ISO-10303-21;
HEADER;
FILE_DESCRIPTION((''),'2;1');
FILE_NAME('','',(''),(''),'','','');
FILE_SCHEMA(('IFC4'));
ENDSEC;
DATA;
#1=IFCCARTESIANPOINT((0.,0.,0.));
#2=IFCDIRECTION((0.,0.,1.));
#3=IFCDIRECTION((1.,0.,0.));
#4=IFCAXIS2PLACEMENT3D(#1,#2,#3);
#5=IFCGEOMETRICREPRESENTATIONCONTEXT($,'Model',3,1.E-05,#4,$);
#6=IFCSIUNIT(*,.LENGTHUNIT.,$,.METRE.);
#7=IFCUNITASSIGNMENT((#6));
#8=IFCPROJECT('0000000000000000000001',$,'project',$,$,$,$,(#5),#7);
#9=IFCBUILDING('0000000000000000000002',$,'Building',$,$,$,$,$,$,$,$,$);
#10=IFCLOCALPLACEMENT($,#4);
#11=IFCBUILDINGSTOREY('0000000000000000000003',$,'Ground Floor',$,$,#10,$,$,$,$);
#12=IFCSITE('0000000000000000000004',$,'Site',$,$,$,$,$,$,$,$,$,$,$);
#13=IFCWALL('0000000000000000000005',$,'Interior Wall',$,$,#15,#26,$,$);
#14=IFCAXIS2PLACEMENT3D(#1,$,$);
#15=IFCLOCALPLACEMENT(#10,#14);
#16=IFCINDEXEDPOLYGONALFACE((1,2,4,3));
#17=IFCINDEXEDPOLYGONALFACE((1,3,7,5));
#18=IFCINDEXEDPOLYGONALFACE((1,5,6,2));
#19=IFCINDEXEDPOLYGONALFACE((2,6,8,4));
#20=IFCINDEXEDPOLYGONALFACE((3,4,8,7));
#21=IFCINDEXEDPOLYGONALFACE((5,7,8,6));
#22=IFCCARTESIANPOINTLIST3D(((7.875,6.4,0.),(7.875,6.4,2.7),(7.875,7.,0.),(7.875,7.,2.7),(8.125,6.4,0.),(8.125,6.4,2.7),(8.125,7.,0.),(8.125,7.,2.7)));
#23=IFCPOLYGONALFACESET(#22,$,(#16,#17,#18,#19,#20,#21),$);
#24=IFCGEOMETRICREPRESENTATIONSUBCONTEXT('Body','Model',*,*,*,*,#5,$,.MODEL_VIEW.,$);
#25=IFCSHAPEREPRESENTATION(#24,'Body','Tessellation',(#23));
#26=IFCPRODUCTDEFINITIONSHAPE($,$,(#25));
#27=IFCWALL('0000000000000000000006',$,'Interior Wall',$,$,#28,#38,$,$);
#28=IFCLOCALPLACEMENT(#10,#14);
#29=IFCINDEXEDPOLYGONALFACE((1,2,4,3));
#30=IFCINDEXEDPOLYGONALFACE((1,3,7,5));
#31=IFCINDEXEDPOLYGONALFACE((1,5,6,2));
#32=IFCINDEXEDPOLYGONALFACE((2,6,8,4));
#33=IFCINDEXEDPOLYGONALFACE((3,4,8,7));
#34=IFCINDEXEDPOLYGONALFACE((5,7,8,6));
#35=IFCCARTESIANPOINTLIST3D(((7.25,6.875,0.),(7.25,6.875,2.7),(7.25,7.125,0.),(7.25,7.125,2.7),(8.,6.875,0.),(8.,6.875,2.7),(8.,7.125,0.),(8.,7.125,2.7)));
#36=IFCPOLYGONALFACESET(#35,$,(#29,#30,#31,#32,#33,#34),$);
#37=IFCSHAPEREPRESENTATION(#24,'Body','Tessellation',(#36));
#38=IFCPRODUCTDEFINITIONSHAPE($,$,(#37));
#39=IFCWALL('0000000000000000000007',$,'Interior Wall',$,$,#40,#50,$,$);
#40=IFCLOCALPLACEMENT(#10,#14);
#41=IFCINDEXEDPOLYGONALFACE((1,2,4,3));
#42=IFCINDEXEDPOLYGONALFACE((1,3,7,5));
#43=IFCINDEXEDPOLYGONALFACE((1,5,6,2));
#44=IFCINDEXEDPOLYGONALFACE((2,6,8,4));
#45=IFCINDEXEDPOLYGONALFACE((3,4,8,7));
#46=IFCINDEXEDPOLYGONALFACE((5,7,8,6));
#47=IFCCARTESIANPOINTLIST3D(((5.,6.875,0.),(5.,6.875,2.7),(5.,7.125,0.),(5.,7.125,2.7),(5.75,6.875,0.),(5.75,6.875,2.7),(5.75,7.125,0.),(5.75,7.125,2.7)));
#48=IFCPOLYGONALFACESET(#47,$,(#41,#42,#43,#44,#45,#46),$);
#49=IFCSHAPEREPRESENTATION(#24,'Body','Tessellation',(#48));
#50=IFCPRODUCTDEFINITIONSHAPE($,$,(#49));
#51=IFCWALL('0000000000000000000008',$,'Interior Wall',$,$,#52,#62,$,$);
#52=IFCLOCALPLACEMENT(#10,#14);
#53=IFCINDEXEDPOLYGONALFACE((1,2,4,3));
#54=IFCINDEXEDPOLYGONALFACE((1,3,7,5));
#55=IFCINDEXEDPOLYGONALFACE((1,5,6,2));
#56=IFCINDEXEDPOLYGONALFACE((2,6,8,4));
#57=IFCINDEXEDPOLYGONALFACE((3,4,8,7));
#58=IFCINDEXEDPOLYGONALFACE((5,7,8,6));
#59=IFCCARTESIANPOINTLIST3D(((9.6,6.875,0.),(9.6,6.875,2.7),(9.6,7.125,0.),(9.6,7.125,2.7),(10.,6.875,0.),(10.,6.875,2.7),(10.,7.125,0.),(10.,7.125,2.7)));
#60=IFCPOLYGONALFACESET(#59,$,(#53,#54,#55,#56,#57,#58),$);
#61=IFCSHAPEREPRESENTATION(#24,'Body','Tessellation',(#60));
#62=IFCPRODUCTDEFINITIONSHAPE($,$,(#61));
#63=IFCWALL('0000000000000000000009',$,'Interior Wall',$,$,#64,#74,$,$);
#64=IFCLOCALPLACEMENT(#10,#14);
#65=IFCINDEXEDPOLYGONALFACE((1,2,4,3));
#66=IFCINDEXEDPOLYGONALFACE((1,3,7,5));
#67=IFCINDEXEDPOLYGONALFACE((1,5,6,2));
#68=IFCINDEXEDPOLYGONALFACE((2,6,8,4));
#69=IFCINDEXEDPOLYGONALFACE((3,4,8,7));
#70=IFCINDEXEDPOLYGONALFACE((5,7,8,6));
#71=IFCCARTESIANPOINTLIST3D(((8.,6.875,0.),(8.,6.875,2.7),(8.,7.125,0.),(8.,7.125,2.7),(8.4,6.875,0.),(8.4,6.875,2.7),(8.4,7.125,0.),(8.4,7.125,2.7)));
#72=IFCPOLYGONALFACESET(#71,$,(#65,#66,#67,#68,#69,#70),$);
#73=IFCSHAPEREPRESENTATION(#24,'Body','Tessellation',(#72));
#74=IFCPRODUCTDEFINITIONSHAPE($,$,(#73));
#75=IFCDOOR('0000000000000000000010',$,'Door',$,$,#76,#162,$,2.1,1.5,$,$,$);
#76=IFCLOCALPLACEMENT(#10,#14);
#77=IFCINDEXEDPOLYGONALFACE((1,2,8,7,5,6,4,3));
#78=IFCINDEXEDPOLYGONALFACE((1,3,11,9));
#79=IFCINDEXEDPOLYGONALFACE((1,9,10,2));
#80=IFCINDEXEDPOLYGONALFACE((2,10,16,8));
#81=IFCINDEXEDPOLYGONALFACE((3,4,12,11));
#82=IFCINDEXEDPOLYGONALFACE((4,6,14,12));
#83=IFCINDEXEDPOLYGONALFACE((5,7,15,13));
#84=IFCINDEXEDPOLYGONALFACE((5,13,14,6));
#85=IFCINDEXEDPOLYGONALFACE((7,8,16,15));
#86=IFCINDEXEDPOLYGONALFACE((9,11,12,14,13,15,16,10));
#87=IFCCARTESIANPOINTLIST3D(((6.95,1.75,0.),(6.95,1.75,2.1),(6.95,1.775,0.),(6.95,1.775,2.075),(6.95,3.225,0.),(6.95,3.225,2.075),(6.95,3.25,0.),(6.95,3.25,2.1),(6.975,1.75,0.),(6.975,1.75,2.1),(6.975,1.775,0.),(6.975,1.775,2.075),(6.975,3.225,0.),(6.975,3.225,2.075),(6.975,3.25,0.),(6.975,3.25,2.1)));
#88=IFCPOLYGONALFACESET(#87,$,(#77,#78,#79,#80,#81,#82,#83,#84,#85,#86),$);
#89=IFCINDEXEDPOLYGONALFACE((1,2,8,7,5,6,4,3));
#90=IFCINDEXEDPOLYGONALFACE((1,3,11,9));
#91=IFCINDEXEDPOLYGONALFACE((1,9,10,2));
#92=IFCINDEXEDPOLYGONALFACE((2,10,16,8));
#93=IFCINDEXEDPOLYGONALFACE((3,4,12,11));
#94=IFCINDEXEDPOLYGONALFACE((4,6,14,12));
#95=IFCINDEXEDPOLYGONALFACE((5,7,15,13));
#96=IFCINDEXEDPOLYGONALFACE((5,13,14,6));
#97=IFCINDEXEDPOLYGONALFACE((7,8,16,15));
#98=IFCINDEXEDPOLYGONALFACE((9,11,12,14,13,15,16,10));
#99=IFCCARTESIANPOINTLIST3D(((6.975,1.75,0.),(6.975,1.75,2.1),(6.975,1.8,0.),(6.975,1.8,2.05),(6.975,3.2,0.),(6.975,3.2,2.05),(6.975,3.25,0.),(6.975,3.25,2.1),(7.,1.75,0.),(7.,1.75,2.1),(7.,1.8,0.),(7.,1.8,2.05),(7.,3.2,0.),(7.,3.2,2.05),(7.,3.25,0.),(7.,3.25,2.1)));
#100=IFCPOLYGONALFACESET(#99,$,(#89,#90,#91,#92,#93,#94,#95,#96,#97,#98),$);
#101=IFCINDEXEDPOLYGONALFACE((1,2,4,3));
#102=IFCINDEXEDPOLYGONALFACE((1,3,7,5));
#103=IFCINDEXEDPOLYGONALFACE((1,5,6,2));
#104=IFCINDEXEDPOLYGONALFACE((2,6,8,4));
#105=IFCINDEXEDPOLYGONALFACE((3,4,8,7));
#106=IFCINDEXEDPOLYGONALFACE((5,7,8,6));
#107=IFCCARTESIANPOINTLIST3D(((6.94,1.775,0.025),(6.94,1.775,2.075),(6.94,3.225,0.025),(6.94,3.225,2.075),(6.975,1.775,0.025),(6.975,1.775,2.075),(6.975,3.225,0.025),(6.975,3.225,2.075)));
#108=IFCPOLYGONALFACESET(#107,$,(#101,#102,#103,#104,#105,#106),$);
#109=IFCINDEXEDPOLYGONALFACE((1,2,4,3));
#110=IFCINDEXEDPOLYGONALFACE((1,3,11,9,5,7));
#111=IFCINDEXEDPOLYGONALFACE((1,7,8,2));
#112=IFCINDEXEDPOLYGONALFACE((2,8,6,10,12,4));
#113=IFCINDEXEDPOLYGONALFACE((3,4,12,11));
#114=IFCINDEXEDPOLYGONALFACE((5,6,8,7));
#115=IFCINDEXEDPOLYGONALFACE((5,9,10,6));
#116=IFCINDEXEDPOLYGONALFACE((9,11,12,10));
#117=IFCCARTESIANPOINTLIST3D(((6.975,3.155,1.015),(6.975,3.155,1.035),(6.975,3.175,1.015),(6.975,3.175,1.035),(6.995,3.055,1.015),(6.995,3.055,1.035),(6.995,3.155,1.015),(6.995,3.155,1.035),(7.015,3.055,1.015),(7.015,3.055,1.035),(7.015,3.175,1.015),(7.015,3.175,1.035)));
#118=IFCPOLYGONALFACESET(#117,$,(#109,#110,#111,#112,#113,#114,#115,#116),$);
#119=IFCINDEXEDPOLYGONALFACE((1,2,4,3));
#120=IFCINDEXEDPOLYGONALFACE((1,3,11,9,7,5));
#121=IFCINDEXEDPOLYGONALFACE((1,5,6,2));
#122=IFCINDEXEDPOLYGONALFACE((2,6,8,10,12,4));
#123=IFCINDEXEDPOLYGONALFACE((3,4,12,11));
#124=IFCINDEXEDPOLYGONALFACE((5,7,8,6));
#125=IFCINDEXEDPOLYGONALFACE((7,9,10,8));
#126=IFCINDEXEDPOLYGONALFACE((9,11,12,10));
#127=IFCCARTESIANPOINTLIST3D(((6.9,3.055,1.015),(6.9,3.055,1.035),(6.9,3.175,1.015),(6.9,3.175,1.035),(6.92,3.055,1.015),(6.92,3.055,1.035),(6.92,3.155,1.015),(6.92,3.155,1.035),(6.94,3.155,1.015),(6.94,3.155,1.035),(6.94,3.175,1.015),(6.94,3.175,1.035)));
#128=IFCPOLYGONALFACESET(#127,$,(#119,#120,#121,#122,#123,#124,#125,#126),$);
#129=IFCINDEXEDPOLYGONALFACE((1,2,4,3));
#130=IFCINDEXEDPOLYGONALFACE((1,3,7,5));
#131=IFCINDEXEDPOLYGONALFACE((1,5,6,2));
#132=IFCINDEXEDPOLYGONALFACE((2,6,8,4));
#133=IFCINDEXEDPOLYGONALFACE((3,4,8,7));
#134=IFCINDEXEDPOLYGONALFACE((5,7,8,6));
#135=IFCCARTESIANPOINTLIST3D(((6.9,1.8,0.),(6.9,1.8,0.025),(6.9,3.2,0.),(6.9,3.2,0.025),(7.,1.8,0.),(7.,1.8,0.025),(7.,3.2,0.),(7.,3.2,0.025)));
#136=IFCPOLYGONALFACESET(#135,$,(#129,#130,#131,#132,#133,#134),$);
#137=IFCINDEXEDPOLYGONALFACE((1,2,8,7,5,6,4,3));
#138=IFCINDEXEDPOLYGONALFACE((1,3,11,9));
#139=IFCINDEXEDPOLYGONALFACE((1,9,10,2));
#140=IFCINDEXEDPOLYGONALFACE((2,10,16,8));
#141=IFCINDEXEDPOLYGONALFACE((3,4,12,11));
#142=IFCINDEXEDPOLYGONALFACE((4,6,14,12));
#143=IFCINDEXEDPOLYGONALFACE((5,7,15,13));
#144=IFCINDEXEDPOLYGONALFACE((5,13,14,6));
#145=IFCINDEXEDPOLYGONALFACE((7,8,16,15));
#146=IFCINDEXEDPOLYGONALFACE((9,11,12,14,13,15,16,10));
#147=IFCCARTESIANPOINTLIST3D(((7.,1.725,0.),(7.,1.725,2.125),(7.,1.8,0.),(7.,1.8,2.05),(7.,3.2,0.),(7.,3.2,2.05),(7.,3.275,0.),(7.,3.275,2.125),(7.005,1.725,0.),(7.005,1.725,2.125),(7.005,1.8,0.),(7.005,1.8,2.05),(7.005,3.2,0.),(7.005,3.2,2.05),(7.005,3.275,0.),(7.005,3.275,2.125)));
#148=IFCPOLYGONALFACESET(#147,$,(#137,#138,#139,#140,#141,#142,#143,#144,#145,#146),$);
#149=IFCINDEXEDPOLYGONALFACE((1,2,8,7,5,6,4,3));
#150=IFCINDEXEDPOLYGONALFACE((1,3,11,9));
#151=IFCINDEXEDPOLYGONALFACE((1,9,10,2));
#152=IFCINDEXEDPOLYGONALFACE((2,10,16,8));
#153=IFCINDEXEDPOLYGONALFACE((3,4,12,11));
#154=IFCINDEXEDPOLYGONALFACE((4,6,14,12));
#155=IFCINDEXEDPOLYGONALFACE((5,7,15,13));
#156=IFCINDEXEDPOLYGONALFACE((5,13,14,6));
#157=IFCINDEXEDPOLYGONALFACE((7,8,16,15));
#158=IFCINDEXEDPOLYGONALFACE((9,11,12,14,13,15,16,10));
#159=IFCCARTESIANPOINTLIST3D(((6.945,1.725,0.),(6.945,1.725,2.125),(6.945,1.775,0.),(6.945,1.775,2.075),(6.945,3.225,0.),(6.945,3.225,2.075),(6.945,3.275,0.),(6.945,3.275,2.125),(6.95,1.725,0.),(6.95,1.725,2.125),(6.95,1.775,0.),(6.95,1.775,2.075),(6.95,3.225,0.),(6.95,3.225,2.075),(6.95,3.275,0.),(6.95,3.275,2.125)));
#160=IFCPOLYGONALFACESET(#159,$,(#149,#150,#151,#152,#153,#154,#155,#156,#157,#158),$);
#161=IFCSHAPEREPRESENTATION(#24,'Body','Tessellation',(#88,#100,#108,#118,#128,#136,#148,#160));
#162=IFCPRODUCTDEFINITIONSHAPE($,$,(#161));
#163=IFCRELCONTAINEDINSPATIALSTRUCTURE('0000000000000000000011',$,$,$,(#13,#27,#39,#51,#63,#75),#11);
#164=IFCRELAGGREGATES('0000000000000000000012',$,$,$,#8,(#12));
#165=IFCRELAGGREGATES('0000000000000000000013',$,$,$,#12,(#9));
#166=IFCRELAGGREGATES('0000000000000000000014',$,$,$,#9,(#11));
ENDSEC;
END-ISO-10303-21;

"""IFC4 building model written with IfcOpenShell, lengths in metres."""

from ifc_helpers import new_model, si_unit, frame, origin_with_axes, place, context, subcontext, project, spatial, line, indexed_curve, outline, extrude, element, save


model = new_model("IFC4")

# Units and contexts
model_context = context("Model", 3, precision=1e-05, world=origin_with_axes())
body_context = subcontext(model_context, "Body", "Model", "MODEL_VIEW")
ifc_project = project(units=[si_unit("LENGTHUNIT", "METRE")], contexts=[model_context])

# Site, building, storey
site = spatial("IfcSite", under=ifc_project, Name="Site")
building = spatial("IfcBuilding", under=site, Name="Building")
storey_placement = place(None, origin_with_axes())
storey = spatial("IfcBuildingStorey", under=building, at=storey_placement, Name="Ground Floor")

# Walls
for number, where, z_axis, x_axis, name in (
    (1, (8.0, 6.4, 0.0), (0.0, 0.0, 1.0), (0.0, 1.0, 0.0), "Interior Wall"),
):
    element("IfcWall", number, at=place(storey_placement, frame(where, z_axis=z_axis, x_axis=x_axis)), inside=storey, Name=name, context=body_context, shape_type="SweptSolid", body=[
        extrude(outline(indexed_curve([(0.0, 0.0), (0.0, 0.25), (0.6, 0.25), (0.6, 0.0), (0.0, 0.0)], self_intersect=False)), frame((0.0, -0.125, 0.0), z_axis=(0.0, 0.0, 1.0), x_axis=(1.0, 0.0, 0.0)), (0.0, 0.0, 1.0), 2.7),
    ])
for number, where, z_axis, x_axis, name in (
    (2, (8.0, 7.0, 0.0), (0.0, 0.0, 1.0), (-1.0, 0.0, 0.0), "Interior Wall"),
    (3, (5.75, 7.0, 0.0), (0.0, 0.0, 1.0), (-1.0, 0.0, 0.0), "Interior Wall"),
):
    element("IfcWall", number, at=place(storey_placement, frame(where, z_axis=z_axis, x_axis=x_axis)), inside=storey, Name=name, context=body_context, shape_type="SweptSolid", body=[
        extrude(outline(indexed_curve([(0.0, 0.0), (0.0, 0.25), (0.75, 0.25), (0.75, 0.0), (0.0, 0.0)], self_intersect=False)), frame((0.0, -0.125, 0.0), z_axis=(0.0, 0.0, 1.0), x_axis=(1.0, 0.0, 0.0)), (0.0, 0.0, 1.0), 2.7),
    ])
for number, where, z_axis, x_axis, name in (
    (4, (10.0, 7.0, 0.0), (0.0, 0.0, 1.0), (-1.0, 0.0, 0.0), "Interior Wall"),
    (5, (8.4, 7.0, 0.0), (0.0, 0.0, 1.0), (-1.0, 0.0, 0.0), "Interior Wall"),
):
    element("IfcWall", number, at=place(storey_placement, frame(where, z_axis=z_axis, x_axis=x_axis)), inside=storey, Name=name, context=body_context, shape_type="SweptSolid", body=[
        extrude(outline(indexed_curve([(0.0, 0.0), (0.0, 0.25), (0.4, 0.25), (0.4, 0.0), (0.0, 0.0)], self_intersect=False)), frame((0.0, -0.125, 0.0), z_axis=(0.0, 0.0, 1.0), x_axis=(1.0, 0.0, 0.0)), (0.0, 0.0, 1.0), 2.7),
    ])

# Door
door_1_placement = place(storey_placement, frame((7.0, 1.75, 0.0), z_axis=(0.0, 0.0, 1.0), x_axis=(0.0, 1.0, 0.0)))
element("IfcDoor", 6, at=door_1_placement, inside=storey, Name="Door", OverallHeight=2.1, OverallWidth=1.5, context=body_context, shape_type="SweptSolid", body=[
    extrude(outline(indexed_curve([(0.0, 0.0), (0.0, 2.1), (1.5, 2.1), (1.5, 0.0), (1.475, 0.0), (1.475, 2.075), (0.025, 2.075), (0.025, 0.0)], segments=[line(1, 2, 3, 4, 5, 6, 7, 8, 1)])), frame((0.0, 0.025, 0.0), z_axis=(0.0, -1.0, 0.0), x_axis=(1.0, 0.0, 0.0)), (0.0, 0.0, -1.0), 0.025),
    extrude(outline(indexed_curve([(0.0, 0.0), (0.0, 2.1), (1.5, 2.1), (1.5, 0.0), (1.45, 0.0), (1.45, 2.05), (0.05, 2.05), (0.05, 0.0)], segments=[line(1, 2, 3, 4, 5, 6, 7, 8, 1)])), frame((0.0, 0.0, 0.0), z_axis=(0.0, -1.0, 0.0), x_axis=(1.0, 0.0, 0.0)), (0.0, 0.0, -1.0), 0.025),
    extrude(outline(indexed_curve([(0.0, 0.0), (1.45, 0.0), (1.45, 0.035), (0.0, 0.035)], segments=[line(1, 2, 3, 4, 1)])), frame((0.025, 0.025, 0.025), z_axis=(0.0, 0.0, 1.0), x_axis=(1.0, 0.0, 0.0)), (0.0, 0.0, 1.0), 2.05),
    extrude(outline(indexed_curve([(0.0, 0.0), (0.0, -0.04), (-0.12, -0.04), (-0.12, -0.02), (-0.02, -0.02), (-0.02, 0.0)], segments=[line(1, 2, 3, 4, 5, 6, 1)])), frame((1.425, 0.025, 1.015), z_axis=(0.0, 0.0, 1.0), x_axis=(1.0, 0.0, 0.0)), (0.0, 0.0, 1.0), 0.02),
    extrude(outline(indexed_curve([(0.0, 0.0), (0.0, 0.04), (-0.12, 0.04), (-0.12, 0.02), (-0.02, 0.02), (-0.02, 0.0)], segments=[line(1, 2, 3, 4, 5, 6, 1)])), frame((1.425, 0.06, 1.015), z_axis=(0.0, 0.0, 1.0), x_axis=(1.0, 0.0, 0.0)), (0.0, 0.0, 1.0), 0.02),
    extrude(outline(indexed_curve([(0.0, 0.0), (1.4, 0.0), (1.4, 0.1), (0.0, 0.1)], segments=[line(1, 2, 3, 4, 1)])), frame((0.05, 0.0, 0.0), z_axis=(0.0, 0.0, 1.0), x_axis=(1.0, 0.0, 0.0)), (0.0, 0.0, 1.0), 0.025),
    extrude(outline(indexed_curve([(0.0, 0.0), (0.0, 2.125), (1.55, 2.125), (1.55, 0.0), (1.475, 0.0), (1.475, 2.05), (0.075, 2.05), (0.075, 0.0)], segments=[line(1, 2, 3, 4, 5, 6, 7, 8, 1)])), frame((-0.025, -0.005, 0.0), z_axis=(0.0, -1.0, 0.0), x_axis=(1.0, 0.0, 0.0)), (0.0, 0.0, -1.0), 0.005),
    extrude(outline(indexed_curve([(0.0, 0.0), (0.0, 2.125), (1.55, 2.125), (1.55, 0.0), (1.5, 0.0), (1.5, 2.075), (0.05, 2.075), (0.05, 0.0)], segments=[line(1, 2, 3, 4, 5, 6, 7, 8, 1)])), frame((-0.025, 0.05, 0.0), z_axis=(0.0, -1.0, 0.0), x_axis=(1.0, 0.0, 0.0)), (0.0, 0.0, -1.0), 0.005),
])

save(model, "model.ifc")
